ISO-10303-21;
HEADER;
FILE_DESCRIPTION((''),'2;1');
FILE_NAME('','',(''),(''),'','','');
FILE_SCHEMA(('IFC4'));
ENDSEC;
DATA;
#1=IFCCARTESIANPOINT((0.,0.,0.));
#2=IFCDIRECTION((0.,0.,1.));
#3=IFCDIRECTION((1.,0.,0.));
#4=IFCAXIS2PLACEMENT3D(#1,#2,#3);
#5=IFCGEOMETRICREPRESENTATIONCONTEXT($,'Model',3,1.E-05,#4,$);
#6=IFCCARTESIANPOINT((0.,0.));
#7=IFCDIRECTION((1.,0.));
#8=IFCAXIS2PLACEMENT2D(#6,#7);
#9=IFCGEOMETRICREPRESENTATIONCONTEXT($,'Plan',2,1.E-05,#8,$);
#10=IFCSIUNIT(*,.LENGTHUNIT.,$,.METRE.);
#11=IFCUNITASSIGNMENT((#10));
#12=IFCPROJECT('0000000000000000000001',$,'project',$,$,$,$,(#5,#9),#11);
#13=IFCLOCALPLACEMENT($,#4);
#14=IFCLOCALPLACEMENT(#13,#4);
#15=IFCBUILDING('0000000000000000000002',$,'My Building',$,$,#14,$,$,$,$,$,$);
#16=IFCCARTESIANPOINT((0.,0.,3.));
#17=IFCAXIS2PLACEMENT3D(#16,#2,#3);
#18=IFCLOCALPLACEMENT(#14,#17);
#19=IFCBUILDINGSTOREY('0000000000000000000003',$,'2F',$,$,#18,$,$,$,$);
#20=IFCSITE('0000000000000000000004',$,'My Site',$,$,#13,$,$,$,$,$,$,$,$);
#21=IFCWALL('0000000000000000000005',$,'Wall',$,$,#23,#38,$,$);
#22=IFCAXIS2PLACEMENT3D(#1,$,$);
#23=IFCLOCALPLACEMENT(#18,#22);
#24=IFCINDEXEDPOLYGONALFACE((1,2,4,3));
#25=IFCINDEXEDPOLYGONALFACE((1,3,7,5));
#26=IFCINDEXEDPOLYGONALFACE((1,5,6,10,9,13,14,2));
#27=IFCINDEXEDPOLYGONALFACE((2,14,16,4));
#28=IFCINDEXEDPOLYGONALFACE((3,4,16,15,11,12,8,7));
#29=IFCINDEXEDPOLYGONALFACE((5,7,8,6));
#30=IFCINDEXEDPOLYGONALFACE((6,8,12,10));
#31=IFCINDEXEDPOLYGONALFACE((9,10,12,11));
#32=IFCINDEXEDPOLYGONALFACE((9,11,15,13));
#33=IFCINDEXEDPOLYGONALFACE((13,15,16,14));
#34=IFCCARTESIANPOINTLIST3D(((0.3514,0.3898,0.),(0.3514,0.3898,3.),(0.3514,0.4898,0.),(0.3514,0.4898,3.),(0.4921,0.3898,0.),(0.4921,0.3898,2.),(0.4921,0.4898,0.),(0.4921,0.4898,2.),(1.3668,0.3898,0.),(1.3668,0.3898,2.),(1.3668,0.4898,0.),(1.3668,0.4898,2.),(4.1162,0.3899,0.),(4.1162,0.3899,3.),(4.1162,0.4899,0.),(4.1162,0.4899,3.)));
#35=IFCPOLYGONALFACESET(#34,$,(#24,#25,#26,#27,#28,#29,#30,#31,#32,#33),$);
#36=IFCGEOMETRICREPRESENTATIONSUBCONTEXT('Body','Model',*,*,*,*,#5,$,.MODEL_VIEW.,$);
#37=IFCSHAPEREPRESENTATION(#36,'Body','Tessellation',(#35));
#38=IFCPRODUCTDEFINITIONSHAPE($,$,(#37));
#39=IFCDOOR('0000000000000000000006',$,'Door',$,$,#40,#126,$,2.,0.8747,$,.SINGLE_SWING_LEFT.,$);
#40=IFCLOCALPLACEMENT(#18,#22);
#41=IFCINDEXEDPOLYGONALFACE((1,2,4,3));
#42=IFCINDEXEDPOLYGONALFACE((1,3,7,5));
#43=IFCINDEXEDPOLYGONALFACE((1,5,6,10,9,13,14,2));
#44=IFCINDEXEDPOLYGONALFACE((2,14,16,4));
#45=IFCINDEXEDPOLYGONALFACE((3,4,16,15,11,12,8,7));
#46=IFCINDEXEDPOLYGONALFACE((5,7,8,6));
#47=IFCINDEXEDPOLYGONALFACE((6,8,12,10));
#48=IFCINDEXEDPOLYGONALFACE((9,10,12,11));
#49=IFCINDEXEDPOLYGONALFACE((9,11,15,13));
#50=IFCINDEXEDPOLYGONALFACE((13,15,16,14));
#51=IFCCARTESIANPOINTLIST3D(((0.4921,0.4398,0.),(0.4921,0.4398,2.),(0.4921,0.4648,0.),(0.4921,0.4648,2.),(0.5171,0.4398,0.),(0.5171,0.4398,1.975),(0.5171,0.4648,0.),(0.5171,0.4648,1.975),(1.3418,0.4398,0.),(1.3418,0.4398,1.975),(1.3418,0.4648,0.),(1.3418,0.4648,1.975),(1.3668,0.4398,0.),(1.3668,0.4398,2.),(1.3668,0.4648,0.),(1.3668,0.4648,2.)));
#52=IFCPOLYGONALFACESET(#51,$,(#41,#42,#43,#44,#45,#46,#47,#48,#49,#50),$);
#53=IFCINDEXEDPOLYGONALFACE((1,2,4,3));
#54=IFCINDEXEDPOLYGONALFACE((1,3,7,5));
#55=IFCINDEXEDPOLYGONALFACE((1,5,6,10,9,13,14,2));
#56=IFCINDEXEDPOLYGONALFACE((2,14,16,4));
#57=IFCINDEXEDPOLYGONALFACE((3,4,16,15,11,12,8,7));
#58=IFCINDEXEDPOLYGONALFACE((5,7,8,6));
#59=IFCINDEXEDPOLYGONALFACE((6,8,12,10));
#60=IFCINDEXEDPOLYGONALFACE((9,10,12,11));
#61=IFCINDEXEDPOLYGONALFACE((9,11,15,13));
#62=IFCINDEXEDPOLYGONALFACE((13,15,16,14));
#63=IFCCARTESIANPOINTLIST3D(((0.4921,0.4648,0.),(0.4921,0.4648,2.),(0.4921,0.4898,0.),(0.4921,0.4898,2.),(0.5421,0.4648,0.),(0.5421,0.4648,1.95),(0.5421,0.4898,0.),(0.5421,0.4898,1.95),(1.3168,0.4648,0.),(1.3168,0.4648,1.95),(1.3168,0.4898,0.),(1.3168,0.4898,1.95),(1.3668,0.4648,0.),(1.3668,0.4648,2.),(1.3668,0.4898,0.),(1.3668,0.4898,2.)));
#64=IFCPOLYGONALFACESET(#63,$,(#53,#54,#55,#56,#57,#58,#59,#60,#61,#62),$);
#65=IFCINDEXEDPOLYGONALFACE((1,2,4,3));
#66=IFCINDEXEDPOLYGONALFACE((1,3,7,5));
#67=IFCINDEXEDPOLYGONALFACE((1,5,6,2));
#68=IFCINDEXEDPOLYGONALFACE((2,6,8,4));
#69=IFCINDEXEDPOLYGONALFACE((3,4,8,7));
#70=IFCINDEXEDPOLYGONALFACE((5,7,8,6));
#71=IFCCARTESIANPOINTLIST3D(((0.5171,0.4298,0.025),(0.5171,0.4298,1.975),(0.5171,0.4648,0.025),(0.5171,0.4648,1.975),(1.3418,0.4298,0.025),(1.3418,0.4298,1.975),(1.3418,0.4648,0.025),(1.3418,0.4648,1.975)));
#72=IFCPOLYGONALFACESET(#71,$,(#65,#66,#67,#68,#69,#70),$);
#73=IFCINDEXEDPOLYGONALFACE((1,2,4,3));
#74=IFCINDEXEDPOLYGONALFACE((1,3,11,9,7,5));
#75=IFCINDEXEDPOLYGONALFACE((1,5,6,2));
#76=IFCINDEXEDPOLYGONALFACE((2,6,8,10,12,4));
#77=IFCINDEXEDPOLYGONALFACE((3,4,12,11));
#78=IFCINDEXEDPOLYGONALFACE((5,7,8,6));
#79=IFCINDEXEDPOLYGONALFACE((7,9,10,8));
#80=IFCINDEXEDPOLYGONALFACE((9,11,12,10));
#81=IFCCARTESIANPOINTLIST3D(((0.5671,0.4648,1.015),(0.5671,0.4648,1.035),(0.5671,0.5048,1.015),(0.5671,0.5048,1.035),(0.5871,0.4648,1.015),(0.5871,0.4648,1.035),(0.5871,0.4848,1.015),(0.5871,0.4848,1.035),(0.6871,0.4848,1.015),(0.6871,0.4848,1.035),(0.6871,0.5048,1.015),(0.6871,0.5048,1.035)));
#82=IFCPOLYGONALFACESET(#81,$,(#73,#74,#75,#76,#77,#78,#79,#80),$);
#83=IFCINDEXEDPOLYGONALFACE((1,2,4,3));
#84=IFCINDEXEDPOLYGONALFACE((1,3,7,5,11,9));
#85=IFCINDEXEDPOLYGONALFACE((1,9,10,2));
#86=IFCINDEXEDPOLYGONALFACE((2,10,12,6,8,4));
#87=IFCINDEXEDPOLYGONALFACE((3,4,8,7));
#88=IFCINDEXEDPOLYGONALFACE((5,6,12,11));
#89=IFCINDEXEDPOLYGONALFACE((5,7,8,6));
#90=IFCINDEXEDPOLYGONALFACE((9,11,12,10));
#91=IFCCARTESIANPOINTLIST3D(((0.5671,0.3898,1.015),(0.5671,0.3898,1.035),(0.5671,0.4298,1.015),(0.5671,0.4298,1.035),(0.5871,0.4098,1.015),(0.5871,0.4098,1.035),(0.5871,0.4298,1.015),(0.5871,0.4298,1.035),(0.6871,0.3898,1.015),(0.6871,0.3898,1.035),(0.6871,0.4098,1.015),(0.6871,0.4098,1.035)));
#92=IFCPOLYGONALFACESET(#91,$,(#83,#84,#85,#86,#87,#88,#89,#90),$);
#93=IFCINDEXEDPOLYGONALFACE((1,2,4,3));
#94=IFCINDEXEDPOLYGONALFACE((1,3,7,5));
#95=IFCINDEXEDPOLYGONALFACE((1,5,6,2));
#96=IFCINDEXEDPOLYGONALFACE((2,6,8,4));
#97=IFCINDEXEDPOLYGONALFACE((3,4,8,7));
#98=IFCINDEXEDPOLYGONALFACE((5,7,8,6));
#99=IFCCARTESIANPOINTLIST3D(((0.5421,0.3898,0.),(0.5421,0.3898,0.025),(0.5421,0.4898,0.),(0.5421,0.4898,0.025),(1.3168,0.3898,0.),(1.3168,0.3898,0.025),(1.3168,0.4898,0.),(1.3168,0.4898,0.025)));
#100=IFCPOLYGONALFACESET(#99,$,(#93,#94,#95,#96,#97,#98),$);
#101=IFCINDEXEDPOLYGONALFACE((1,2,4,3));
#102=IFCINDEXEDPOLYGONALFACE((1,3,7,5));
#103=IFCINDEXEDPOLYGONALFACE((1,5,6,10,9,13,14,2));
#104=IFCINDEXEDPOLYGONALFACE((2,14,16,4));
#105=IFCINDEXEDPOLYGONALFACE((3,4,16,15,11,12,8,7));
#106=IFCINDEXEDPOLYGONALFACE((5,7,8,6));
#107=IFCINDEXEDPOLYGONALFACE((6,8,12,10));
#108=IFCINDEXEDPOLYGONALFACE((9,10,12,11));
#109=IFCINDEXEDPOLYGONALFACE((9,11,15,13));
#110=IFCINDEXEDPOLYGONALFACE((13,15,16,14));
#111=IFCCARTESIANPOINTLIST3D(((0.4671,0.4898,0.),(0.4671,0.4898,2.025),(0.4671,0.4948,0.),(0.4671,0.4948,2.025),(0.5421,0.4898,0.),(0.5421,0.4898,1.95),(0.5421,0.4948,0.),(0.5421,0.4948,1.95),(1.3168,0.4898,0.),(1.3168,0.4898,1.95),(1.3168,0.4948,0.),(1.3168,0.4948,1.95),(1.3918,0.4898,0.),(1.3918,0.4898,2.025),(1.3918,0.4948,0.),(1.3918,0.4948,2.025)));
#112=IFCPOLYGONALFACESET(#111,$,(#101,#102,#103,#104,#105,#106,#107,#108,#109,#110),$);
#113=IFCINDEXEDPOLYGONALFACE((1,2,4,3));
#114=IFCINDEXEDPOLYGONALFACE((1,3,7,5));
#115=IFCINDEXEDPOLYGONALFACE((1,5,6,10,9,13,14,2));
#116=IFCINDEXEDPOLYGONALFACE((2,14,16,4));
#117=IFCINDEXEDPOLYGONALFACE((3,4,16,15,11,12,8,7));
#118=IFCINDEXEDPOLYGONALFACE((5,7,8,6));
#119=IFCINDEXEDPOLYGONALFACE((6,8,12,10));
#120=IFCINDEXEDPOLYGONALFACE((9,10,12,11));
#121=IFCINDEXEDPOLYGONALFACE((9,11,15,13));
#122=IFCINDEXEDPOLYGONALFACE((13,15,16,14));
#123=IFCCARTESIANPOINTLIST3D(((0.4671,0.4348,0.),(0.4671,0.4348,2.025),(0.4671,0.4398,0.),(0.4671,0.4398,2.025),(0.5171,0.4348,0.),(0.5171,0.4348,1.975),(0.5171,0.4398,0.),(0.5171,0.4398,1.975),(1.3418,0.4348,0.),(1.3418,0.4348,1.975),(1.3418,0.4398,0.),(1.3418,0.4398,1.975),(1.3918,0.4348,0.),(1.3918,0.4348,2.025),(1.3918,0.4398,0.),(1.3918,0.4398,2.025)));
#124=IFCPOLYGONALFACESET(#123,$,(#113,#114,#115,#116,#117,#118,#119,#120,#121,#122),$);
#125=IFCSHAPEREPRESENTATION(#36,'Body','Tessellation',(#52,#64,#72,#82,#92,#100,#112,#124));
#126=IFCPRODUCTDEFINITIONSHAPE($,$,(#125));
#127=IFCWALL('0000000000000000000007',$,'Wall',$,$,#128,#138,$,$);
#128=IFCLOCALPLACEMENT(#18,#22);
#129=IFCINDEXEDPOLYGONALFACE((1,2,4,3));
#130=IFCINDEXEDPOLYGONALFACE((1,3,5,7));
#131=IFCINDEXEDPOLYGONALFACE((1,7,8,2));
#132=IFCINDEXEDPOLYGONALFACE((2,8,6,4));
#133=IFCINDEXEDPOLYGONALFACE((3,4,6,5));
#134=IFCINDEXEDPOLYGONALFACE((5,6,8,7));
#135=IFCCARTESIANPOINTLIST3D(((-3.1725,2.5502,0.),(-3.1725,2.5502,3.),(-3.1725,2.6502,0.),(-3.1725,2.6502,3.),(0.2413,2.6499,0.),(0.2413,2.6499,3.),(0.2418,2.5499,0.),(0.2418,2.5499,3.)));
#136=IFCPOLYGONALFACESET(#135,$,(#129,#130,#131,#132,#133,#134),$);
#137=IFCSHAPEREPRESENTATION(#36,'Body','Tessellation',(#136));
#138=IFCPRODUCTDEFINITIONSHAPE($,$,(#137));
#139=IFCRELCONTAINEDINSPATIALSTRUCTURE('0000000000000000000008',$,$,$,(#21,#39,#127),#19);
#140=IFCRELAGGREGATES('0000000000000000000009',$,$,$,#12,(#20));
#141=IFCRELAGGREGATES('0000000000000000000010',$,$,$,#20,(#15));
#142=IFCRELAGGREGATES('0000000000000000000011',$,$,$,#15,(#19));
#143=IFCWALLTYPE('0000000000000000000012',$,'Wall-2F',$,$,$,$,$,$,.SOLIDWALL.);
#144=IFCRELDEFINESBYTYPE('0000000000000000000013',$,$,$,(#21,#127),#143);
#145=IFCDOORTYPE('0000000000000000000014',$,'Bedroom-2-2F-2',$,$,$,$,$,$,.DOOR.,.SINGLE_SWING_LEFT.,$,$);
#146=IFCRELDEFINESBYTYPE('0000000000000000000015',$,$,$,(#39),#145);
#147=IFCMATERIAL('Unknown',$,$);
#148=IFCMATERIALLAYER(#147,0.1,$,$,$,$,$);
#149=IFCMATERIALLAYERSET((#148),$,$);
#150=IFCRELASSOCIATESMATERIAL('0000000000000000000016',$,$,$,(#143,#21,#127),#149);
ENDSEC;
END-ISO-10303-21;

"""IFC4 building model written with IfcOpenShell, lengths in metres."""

from ifc_helpers import new_model, entity, si_unit, frame, origin_with_axes, origin_2d_with_axis, place, context, subcontext, project, spatial, line, indexed_curve, outline, extrude, shape, source, transform, mapped, material, layer, layer_set, layer_usage, type_object, type_shapes, element, fill, save


model = new_model("IFC4")

# Units and contexts
model_context = context("Model", 3, precision=1e-05, world=origin_with_axes())
plan_context = context("Plan", 2, precision=1e-05, world=origin_2d_with_axis())
body_context_1 = subcontext(model_context, "Body", "Model", "MODEL_VIEW")
body_context_2 = subcontext(plan_context, "Body", "Plan", "PLAN_VIEW")
ifc_project = project(units=[si_unit("LENGTHUNIT", "METRE")], contexts=[model_context, plan_context])

# Site, building, storey
site_placement = place(None, origin_with_axes())
site = spatial("IfcSite", under=ifc_project, at=site_placement, Name="My Site")
building_placement = place(site_placement, origin_with_axes())
building = spatial("IfcBuilding", under=site, at=building_placement, Name="My Building")
storey_placement = place(building_placement, frame((0.0, 0.0, 3.0), z_axis=(0.0, 0.0, 1.0), x_axis=(1.0, 0.0, 0.0)))
storey = spatial("IfcBuildingStorey", under=building, at=storey_placement, Name="2F")

# Shared definitions
ifc_material = material(Name="Unknown")

# Shared definitions
ifc_layer_1 = layer(ifc_material, 0.1)
ifc_layer_set_1 = layer_set([ifc_layer_1])
wall_type = type_object("IfcWallType", Name="Wall-2F", PredefinedType="SOLIDWALL", material=ifc_layer_set_1)

# Wall, opening, door
ifc_layer_usage_1 = layer_usage(ifc_layer_set_1, "AXIS2", "POSITIVE", 0.0)
wall_1_placement = place(storey_placement, frame((0.3514, 0.3898, 0.0), z_axis=(0.0, 0.0, 1.0), x_axis=(1.0, 0.000024, 0.0)))
wall_1 = element("IfcWall", 1, at=wall_1_placement, inside=storey, type_object=wall_type, material=ifc_layer_usage_1, Name="Wall", context=body_context_1, shape_type="SweptSolid", body=[
    extrude(outline(indexed_curve([(0.0, 0.0), (0.0, 0.1), (3.7648, 0.1), (3.7648, 0.0)], segments=[line(1, 2, 3, 4, 1)])), origin_with_axes(), (0.0, 0.0, 1.0), 3.0),
])
shared_shape_1 = source(origin_with_axes(), body_context_1, "Body", "SweptSolid", [
    extrude(outline(indexed_curve([(0.0, 0.0), (0.8747, 0.0), (0.8747, 2.0), (0.0, 2.0)], segments=[line(1, 2, 3, 4, 1)])), frame((0.0, -0.6, 0.0), z_axis=(0.0, -1.0, 0.0), x_axis=(1.0, 0.0, 0.0)), (0.0, 0.0, -1.0), 1.2),
])
opening_1_placement = place(wall_1_placement, frame((0.1407, 0.015, 0.0), z_axis=(0.0, 0.0, 1.0), x_axis=(1.0, -0.000001, 0.0)))
opening_1 = element("IfcOpeningElement", 2, at=opening_1_placement, cuts=wall_1, PredefinedType="OPENING", context=body_context_1, shape_type="MappedRepresentation", body=[
    mapped(shared_shape_1, transform((0.0, 0.0, 0.0), x_axis=(1.0, 0.0, 0.0), y_axis=(0.0, 1.0, 0.0), z_axis=(0.0, 0.0, 1.0), scale=1.0)),
])
door_type_1 = type_object("IfcDoorType", Name="Bedroom-2-2F-2", OperationType="SINGLE_SWING_LEFT", PredefinedType="DOOR")
shared_shape_2 = source(origin_with_axes(), body_context_1, "Body", "SweptSolid", [
    extrude(outline(indexed_curve([(0.0, 0.0), (0.0, 2.0), (0.8747, 2.0), (0.8747, 0.0), (0.8497, 0.0), (0.8497, 1.975), (0.025, 1.975), (0.025, 0.0)], segments=[line(1, 2, 3, 4, 5, 6, 7, 8, 1)])), frame((0.0, 0.025, 0.0), z_axis=(0.0, -1.0, 0.0), x_axis=(1.0, 0.0, 0.0)), (0.0, 0.0, -1.0), 0.025),
    extrude(outline(indexed_curve([(0.0, 0.0), (0.0, 2.0), (0.8747, 2.0), (0.8747, 0.0), (0.8247, 0.0), (0.8247, 1.95), (0.05, 1.95), (0.05, 0.0)], segments=[line(1, 2, 3, 4, 5, 6, 7, 8, 1)])), frame((0.0, 0.0, 0.0), z_axis=(0.0, -1.0, 0.0), x_axis=(1.0, 0.0, 0.0)), (0.0, 0.0, -1.0), 0.025),
    extrude(outline(indexed_curve([(0.0, 0.0), (0.8247, 0.0), (0.8247, 0.035), (0.0, 0.035)], segments=[line(1, 2, 3, 4, 1)])), frame((0.025, 0.025, 0.025), z_axis=(0.0, 0.0, 1.0), x_axis=(1.0, 0.0, 0.0)), (0.0, 0.0, 1.0), 1.95),
    extrude(outline(indexed_curve([(0.0, 0.0), (0.0, -0.04), (-0.12, -0.04), (-0.12, -0.02), (-0.02, -0.02), (-0.02, 0.0)], segments=[line(1, 2, 3, 4, 5, 6, 1)])), frame((0.7997, 0.025, 1.015), z_axis=(0.0, 0.0, 1.0), x_axis=(1.0, 0.0, 0.0)), (0.0, 0.0, 1.0), 0.02),
    extrude(outline(indexed_curve([(0.0, 0.0), (0.0, 0.04), (-0.12, 0.04), (-0.12, 0.02), (-0.02, 0.02), (-0.02, 0.0)], segments=[line(1, 2, 3, 4, 5, 6, 1)])), frame((0.7997, 0.06, 1.015), z_axis=(0.0, 0.0, 1.0), x_axis=(1.0, 0.0, 0.0)), (0.0, 0.0, 1.0), 0.02),
    extrude(outline(indexed_curve([(0.0, 0.0), (0.7747, 0.0), (0.7747, 0.1), (0.0, 0.1)], segments=[line(1, 2, 3, 4, 1)])), frame((0.05, 0.0, 0.0), z_axis=(0.0, 0.0, 1.0), x_axis=(1.0, 0.0, 0.0)), (0.0, 0.0, 1.0), 0.025),
    extrude(outline(indexed_curve([(0.0, 0.0), (0.0, 2.025), (0.9247, 2.025), (0.9247, 0.0), (0.8497, 0.0), (0.8497, 1.95), (0.075, 1.95), (0.075, 0.0)], segments=[line(1, 2, 3, 4, 5, 6, 7, 8, 1)])), frame((-0.025, -0.005, 0.0), z_axis=(0.0, -1.0, 0.0), x_axis=(1.0, 0.0, 0.0)), (0.0, 0.0, -1.0), 0.005),
    extrude(outline(indexed_curve([(0.0, 0.0), (0.0, 2.025), (0.9247, 2.025), (0.9247, 0.0), (0.8747, 0.0), (0.8747, 1.975), (0.05, 1.975), (0.05, 0.0)], segments=[line(1, 2, 3, 4, 5, 6, 7, 8, 1)])), frame((-0.025, 0.05, 0.0), z_axis=(0.0, -1.0, 0.0), x_axis=(1.0, 0.0, 0.0)), (0.0, 0.0, -1.0), 0.005),
])
shared_shape_3 = source(origin_with_axes(), body_context_2, "Body", "Curve2D", [
    entity("IfcIndexedPolyCurve", entity("IfcCartesianPointList2D", [[0.0, 0.0], [0.0, 0.05], [0.025, 0.05], [0.025, 0.025], [0.05, 0.025], [0.05, 0.0]]), [entity("IfcLineIndex", [1, 2, 3, 4, 5, 6, 1])]),
    entity("IfcIndexedPolyCurve", entity("IfcCartesianPointList2D", [[0.8747, 0.0], [0.8747, 0.05], [0.8497, 0.05], [0.8497, 0.025], [0.8247, 0.025], [0.8247, 0.0]]), [entity("IfcLineIndex", [1, 2, 3, 4, 5, 6, 1])]),
    entity("IfcTrimmedCurve", entity("IfcEllipse", entity("IfcAxis2Placement2D", entity("IfcCartesianPoint", [0.06, 0.05]), entity("IfcDirection", [1.0, 0.0])), 0.7897, 0.8247), [entity("IfcCartesianPoint", [0.8497, 0.05])], [entity("IfcCartesianPoint", [0.06, 0.8747])], True, "CARTESIAN"),
    entity("IfcIndexedPolyCurve", entity("IfcCartesianPointList2D", [[0.025, 0.05], [0.06, 0.05], [0.06, 0.8747], [0.025, 0.8747]]), [entity("IfcLineIndex", [1, 2, 3, 4, 1])]),
])
type_shapes(door_type_1, [shared_shape_2, shared_shape_3])
door_1_placement = place(opening_1_placement, frame((0.8747, 0.085, 0.0), z_axis=(0.0, 0.0, 1.0), x_axis=(-1.0, 0.0, 0.0)))
door_1 = element("IfcDoor", 3, at=door_1_placement, inside=storey, type_object=door_type_1, Name="Door", OperationType="SINGLE_SWING_LEFT", OverallHeight=2.0, OverallWidth=0.8747, shapes=[
    shape(body_context_1, "Body", "MappedRepresentation", [mapped(shared_shape_2, transform((0.0, 0.0, 0.0), x_axis=(1.0, 0.0, 0.0), y_axis=(0.0, 1.0, 0.0), z_axis=(0.0, 0.0, 1.0), scale=1.0))]),
    shape(body_context_2, "Body", "MappedRepresentation", [mapped(shared_shape_3, transform((0.0, 0.0, 0.0), x_axis=(1.0, 0.0, 0.0), y_axis=(0.0, 1.0, 0.0), z_axis=(0.0, 0.0, 1.0), scale=1.0))]),
])
fill(opening_1, door_1)

# Wall
ifc_layer_usage_2 = layer_usage(ifc_layer_set_1, "AXIS2", "POSITIVE", 0.0)
wall_2_placement = place(storey_placement, frame((-3.1725, 2.5502, 0.0), z_axis=(0.0, 0.0, 1.0), x_axis=(1.0, -0.000076, 0.0)))
element("IfcWall", 4, at=wall_2_placement, inside=storey, type_object=wall_type, material=ifc_layer_usage_2, Name="Wall", context=body_context_1, shape_type="SweptSolid", body=[
    extrude(outline(indexed_curve([(0.0, 0.0), (0.0, 0.1), (3.4138, 0.1), (3.4144, 0.0)], segments=[line(1, 2, 3, 4, 1)])), origin_with_axes(), (0.0, 0.0, 1.0), 3.0),
])

save(model, "model.ifc")
